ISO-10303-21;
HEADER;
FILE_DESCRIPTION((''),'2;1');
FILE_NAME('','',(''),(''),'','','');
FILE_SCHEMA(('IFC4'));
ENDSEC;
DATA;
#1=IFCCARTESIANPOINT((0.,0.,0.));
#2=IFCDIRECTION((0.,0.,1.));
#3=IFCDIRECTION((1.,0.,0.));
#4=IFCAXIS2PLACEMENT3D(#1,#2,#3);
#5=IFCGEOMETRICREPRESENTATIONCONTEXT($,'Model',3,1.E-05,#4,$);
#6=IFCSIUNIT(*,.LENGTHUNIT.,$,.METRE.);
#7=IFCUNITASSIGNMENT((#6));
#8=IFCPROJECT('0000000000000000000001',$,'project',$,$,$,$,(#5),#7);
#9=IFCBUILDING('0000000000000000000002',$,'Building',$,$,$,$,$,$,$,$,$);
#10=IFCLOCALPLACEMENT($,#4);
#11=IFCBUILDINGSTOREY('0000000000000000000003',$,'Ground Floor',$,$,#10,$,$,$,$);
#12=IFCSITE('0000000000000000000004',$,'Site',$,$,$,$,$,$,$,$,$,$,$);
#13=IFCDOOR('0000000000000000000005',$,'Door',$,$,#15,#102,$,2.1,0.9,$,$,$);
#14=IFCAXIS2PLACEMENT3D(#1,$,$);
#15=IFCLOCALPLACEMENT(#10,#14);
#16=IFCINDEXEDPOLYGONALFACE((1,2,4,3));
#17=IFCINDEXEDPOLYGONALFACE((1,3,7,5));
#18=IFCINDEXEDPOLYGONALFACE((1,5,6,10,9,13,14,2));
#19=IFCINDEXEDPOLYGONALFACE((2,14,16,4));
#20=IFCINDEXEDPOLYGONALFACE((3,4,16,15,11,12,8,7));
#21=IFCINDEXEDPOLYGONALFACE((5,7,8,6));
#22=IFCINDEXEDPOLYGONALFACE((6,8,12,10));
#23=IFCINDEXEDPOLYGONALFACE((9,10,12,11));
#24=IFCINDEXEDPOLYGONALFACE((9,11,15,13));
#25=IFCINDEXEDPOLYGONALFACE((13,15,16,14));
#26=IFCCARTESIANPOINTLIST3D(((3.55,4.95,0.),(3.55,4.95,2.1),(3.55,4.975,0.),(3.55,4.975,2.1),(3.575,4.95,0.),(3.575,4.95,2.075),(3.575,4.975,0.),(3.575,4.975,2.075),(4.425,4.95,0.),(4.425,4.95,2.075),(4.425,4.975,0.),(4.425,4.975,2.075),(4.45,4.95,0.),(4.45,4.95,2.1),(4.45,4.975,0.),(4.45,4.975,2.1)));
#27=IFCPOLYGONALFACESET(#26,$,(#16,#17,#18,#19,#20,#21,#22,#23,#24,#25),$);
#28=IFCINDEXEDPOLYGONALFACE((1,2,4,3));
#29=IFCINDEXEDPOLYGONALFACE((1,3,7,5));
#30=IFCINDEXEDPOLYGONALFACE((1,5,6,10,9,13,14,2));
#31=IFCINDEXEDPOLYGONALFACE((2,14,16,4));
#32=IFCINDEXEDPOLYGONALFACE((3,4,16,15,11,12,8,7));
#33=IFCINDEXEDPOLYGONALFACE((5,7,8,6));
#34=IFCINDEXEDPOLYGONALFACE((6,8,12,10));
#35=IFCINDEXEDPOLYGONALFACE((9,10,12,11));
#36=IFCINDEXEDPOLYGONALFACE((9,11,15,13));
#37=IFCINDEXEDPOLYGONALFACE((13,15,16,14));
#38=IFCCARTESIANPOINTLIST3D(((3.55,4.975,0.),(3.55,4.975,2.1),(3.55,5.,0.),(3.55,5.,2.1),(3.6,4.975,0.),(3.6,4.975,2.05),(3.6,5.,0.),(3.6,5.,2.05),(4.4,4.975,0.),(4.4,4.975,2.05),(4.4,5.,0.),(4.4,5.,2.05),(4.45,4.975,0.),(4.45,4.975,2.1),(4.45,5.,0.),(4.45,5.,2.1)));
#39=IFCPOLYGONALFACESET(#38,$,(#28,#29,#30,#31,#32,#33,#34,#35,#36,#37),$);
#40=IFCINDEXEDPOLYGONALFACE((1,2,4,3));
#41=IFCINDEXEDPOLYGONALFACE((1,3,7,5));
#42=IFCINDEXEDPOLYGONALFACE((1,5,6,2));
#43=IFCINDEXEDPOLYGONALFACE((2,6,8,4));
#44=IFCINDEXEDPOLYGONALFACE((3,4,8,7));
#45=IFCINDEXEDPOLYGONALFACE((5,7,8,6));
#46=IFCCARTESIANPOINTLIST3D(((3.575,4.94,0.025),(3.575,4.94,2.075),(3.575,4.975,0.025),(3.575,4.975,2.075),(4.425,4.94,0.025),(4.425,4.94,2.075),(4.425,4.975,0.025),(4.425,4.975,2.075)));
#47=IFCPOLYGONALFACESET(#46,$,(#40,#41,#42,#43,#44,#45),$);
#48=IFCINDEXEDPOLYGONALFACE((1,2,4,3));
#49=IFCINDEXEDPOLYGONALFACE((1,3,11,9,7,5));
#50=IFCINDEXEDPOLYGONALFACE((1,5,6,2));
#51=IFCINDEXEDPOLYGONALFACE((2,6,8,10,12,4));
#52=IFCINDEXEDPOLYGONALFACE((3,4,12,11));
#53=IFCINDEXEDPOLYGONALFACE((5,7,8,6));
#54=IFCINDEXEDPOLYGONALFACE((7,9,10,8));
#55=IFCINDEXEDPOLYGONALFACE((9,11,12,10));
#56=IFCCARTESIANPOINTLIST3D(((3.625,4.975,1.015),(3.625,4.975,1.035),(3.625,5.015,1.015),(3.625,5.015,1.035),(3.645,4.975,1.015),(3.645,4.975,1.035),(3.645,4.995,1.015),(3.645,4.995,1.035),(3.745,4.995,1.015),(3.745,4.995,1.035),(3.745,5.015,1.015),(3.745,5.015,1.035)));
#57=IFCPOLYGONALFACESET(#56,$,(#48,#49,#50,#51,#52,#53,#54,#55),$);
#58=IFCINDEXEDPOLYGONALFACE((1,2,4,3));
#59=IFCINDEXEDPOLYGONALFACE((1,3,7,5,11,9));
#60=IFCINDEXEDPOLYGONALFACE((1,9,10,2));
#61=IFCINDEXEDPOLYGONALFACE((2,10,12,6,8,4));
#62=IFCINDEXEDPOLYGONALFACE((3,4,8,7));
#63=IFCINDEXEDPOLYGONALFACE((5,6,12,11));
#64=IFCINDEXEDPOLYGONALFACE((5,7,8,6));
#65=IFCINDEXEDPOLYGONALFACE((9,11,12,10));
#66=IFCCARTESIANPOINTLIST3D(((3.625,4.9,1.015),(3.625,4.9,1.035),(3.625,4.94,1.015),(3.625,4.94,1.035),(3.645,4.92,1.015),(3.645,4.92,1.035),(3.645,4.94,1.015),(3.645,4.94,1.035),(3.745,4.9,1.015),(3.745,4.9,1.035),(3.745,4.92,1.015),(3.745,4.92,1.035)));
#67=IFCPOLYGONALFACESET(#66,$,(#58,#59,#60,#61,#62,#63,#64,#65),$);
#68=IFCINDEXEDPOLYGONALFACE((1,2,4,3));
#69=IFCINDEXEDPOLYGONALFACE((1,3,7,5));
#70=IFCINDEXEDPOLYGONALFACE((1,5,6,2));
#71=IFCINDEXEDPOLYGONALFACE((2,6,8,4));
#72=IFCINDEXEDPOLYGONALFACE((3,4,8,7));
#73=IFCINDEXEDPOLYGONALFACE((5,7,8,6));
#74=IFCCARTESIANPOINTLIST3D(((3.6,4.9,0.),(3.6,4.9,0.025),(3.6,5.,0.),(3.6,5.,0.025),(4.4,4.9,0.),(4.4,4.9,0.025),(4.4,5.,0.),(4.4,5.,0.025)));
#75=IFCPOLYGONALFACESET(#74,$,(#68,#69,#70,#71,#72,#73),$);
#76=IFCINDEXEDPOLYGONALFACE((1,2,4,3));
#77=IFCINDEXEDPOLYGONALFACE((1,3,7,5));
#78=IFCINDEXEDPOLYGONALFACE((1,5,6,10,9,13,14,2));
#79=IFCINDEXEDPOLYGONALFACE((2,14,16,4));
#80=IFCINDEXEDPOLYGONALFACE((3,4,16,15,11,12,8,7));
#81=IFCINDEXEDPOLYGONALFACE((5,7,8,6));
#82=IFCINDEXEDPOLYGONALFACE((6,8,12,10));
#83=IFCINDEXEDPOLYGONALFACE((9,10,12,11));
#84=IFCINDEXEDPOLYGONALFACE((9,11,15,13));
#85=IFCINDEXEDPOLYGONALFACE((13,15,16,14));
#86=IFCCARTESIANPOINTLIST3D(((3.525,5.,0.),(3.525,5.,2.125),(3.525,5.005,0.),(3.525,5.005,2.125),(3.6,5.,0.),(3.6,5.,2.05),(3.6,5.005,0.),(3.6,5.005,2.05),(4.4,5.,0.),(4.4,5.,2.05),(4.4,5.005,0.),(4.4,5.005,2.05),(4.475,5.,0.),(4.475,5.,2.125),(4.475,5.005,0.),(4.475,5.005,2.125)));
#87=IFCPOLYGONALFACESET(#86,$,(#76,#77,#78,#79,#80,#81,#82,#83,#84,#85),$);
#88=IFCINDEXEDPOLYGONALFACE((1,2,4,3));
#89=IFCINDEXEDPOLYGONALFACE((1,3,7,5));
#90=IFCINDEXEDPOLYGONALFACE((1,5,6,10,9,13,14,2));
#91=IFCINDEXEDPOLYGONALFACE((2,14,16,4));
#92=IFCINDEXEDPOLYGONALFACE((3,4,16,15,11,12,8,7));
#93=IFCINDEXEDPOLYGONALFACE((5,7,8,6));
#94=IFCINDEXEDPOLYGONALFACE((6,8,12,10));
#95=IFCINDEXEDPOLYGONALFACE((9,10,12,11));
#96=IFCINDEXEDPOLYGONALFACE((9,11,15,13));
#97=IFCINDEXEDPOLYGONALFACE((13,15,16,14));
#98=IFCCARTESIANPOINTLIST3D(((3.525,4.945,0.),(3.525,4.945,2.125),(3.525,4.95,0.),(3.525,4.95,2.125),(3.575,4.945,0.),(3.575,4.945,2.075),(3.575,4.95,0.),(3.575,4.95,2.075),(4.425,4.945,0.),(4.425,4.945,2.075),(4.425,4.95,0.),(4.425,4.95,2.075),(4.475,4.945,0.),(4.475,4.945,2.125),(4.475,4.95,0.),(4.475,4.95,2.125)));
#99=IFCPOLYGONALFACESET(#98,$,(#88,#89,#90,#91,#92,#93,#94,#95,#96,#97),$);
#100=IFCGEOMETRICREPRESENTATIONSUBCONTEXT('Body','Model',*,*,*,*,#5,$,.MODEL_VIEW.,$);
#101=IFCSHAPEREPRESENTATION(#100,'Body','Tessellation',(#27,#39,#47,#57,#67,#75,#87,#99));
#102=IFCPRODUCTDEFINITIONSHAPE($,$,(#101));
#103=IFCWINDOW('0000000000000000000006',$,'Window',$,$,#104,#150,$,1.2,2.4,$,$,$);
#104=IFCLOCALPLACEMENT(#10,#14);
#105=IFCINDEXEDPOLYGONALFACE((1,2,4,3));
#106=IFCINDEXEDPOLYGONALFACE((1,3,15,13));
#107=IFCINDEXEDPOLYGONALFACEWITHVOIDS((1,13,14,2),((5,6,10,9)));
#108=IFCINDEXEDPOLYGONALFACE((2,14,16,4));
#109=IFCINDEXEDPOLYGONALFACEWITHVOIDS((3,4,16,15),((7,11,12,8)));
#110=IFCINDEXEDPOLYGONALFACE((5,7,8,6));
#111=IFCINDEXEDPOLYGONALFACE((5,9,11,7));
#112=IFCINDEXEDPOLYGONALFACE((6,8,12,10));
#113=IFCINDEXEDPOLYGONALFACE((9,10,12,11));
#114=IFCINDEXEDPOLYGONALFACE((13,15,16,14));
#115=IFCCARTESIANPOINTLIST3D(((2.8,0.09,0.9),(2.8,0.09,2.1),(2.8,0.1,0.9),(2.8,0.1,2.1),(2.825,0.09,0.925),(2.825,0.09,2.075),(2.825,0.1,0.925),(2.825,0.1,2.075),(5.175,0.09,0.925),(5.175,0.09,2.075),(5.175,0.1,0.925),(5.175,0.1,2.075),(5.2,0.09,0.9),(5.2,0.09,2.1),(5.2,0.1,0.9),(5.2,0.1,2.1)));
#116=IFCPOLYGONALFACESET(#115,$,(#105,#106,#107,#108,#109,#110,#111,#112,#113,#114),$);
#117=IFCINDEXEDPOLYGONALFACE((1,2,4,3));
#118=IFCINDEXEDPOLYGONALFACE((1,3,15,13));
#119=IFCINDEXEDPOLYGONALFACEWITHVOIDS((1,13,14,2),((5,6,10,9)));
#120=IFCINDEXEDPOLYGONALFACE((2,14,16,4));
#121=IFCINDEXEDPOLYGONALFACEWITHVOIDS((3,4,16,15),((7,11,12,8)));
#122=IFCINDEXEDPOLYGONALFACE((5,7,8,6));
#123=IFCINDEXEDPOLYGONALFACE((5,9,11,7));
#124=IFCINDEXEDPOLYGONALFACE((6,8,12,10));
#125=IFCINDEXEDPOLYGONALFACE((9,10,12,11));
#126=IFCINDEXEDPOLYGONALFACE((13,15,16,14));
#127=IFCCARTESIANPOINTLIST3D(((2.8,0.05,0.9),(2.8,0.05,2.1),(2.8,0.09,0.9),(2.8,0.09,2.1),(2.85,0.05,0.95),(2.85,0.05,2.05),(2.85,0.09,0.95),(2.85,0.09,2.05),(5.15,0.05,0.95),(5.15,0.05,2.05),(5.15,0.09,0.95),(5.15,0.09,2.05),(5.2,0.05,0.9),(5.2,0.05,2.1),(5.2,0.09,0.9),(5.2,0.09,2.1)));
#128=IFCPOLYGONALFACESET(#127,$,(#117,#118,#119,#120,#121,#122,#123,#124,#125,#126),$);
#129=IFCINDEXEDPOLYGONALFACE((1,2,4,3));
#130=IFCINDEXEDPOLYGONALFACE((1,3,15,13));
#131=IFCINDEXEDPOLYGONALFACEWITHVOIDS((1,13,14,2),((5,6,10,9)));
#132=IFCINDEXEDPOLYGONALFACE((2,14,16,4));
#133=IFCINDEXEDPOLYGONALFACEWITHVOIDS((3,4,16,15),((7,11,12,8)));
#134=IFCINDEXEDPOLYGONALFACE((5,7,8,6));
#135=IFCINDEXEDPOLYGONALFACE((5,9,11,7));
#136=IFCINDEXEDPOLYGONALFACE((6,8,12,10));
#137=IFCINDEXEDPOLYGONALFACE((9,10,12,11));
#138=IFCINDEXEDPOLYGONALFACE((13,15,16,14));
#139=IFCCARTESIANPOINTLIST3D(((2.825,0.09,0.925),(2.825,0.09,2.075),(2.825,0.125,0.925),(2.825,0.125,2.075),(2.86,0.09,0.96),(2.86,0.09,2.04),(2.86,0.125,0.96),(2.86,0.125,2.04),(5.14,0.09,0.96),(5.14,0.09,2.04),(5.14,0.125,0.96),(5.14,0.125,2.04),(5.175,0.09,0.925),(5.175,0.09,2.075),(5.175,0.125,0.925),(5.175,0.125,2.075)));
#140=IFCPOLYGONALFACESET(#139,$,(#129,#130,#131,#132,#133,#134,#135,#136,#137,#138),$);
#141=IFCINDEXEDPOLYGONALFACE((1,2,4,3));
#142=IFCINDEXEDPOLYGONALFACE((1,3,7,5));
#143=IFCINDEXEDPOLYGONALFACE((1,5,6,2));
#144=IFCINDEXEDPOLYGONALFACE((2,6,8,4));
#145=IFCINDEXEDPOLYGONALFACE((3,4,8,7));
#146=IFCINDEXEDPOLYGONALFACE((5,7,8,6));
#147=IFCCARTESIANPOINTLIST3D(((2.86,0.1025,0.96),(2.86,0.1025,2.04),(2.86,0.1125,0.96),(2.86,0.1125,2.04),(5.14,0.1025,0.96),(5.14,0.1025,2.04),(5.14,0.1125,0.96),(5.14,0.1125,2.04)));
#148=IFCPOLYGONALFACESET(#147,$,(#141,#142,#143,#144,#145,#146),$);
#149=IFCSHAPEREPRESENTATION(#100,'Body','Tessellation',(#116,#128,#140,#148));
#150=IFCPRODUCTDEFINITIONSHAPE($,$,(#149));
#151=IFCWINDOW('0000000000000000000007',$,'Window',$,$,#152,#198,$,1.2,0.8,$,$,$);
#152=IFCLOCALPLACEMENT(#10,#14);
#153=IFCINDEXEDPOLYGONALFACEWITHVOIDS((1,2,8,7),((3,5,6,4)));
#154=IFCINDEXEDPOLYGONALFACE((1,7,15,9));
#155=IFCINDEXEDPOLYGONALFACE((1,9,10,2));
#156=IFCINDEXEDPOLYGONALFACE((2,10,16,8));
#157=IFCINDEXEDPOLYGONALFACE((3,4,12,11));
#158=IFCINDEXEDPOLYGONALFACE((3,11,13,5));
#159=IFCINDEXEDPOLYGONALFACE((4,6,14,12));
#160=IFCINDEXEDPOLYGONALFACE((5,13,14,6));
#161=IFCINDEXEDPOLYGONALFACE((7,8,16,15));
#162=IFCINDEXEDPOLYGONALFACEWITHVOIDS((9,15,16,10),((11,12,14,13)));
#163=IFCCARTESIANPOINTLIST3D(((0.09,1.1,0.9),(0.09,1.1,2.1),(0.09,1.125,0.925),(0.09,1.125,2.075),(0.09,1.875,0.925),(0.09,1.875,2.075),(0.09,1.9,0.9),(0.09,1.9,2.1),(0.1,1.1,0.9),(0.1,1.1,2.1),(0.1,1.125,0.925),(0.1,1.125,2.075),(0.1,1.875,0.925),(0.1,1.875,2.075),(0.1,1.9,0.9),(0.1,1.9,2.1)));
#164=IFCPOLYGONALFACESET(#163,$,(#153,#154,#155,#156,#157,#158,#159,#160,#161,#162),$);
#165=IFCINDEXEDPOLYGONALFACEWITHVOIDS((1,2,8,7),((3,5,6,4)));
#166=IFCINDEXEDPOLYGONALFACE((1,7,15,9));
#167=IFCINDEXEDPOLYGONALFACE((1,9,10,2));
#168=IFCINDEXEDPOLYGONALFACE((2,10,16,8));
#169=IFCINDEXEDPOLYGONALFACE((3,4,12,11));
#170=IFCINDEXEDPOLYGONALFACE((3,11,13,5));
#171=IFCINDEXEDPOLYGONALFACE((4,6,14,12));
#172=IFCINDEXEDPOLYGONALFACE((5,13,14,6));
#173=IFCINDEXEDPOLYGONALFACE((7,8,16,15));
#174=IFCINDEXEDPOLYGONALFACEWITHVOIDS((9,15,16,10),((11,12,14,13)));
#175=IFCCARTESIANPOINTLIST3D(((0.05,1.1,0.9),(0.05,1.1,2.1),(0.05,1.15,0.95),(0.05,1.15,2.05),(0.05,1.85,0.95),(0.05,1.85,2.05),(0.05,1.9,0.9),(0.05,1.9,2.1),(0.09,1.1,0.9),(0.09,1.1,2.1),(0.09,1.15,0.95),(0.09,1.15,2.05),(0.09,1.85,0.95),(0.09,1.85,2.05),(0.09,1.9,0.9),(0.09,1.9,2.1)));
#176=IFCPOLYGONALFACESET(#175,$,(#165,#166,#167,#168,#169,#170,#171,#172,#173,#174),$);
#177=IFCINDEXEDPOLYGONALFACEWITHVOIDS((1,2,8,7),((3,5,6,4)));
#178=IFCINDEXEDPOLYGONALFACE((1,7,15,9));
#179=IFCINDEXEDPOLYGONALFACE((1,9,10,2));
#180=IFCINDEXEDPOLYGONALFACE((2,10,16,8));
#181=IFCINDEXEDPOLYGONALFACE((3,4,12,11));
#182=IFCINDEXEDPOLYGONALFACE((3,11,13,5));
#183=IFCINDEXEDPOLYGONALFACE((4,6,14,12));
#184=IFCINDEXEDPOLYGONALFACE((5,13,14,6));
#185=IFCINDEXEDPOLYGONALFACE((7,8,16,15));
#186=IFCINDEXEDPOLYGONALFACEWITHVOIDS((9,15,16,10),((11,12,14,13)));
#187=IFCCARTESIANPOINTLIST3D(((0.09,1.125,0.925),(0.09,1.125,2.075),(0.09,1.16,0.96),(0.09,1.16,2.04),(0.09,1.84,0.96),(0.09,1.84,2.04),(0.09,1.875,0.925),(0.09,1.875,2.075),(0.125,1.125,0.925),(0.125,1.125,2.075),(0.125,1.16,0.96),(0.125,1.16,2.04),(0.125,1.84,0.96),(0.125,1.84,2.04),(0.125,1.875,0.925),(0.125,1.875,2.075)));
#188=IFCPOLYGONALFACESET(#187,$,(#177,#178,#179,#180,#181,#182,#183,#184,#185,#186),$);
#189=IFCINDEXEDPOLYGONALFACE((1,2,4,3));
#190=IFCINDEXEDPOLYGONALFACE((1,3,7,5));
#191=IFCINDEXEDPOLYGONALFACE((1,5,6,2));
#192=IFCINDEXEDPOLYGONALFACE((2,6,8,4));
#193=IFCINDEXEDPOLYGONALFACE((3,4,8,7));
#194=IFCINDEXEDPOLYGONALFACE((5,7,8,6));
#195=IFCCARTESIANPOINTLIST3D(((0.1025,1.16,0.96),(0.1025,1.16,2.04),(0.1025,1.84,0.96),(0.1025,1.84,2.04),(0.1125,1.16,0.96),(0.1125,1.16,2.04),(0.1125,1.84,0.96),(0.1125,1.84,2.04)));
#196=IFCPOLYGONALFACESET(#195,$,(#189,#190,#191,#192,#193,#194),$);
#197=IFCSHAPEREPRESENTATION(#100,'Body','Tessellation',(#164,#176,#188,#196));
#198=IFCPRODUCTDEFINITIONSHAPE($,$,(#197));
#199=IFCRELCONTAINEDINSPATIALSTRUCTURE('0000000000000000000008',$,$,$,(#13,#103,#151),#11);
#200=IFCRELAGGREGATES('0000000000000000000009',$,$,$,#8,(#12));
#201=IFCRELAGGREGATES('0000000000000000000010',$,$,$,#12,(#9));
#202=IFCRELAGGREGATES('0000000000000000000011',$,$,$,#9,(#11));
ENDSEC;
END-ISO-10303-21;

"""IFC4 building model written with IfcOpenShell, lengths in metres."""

from ifc_helpers import new_model, si_unit, frame, origin_with_axes, place, context, subcontext, project, spatial, line, indexed_curve, outline, extrude, element, save


model = new_model("IFC4")

# Units and contexts
model_context = context("Model", 3, precision=1e-05, world=origin_with_axes())
body_context = subcontext(model_context, "Body", "Model", "MODEL_VIEW")
ifc_project = project(units=[si_unit("LENGTHUNIT", "METRE")], contexts=[model_context])

# Site, building, storey
site = spatial("IfcSite", under=ifc_project, Name="Site")
building = spatial("IfcBuilding", under=site, Name="Building")
storey_placement = place(None, origin_with_axes())
storey = spatial("IfcBuildingStorey", under=building, at=storey_placement, Name="Ground Floor")

# Door
door_1_placement = place(storey_placement, frame((4.45, 5.0, 0.0), z_axis=(0.0, 0.0, 1.0), x_axis=(-1.0, 0.0, 0.0)))
element("IfcDoor", 1, at=door_1_placement, inside=storey, Name="Door", OverallHeight=2.1, OverallWidth=0.9, context=body_context, shape_type="SweptSolid", body=[
    extrude(outline(indexed_curve([(0.0, 0.0), (0.0, 2.1), (0.9, 2.1), (0.9, 0.0), (0.875, 0.0), (0.875, 2.075), (0.025, 2.075), (0.025, 0.0)], segments=[line(1, 2, 3, 4, 5, 6, 7, 8, 1)])), frame((0.0, 0.025, 0.0), z_axis=(0.0, -1.0, 0.0), x_axis=(1.0, 0.0, 0.0)), (0.0, 0.0, -1.0), 0.025),
    extrude(outline(indexed_curve([(0.0, 0.0), (0.0, 2.1), (0.9, 2.1), (0.9, 0.0), (0.85, 0.0), (0.85, 2.05), (0.05, 2.05), (0.05, 0.0)], segments=[line(1, 2, 3, 4, 5, 6, 7, 8, 1)])), frame((0.0, 0.0, 0.0), z_axis=(0.0, -1.0, 0.0), x_axis=(1.0, 0.0, 0.0)), (0.0, 0.0, -1.0), 0.025),
    extrude(outline(indexed_curve([(0.0, 0.0), (0.85, 0.0), (0.85, 0.035), (0.0, 0.035)], segments=[line(1, 2, 3, 4, 1)])), frame((0.025, 0.025, 0.025), z_axis=(0.0, 0.0, 1.0), x_axis=(1.0, 0.0, 0.0)), (0.0, 0.0, 1.0), 2.05),
    extrude(outline(indexed_curve([(0.0, 0.0), (0.0, -0.04), (-0.12, -0.04), (-0.12, -0.02), (-0.02, -0.02), (-0.02, 0.0)], segments=[line(1, 2, 3, 4, 5, 6, 1)])), frame((0.825, 0.025, 1.015), z_axis=(0.0, 0.0, 1.0), x_axis=(1.0, 0.0, 0.0)), (0.0, 0.0, 1.0), 0.02),
    extrude(outline(indexed_curve([(0.0, 0.0), (0.0, 0.04), (-0.12, 0.04), (-0.12, 0.02), (-0.02, 0.02), (-0.02, 0.0)], segments=[line(1, 2, 3, 4, 5, 6, 1)])), frame((0.825, 0.06, 1.015), z_axis=(0.0, 0.0, 1.0), x_axis=(1.0, 0.0, 0.0)), (0.0, 0.0, 1.0), 0.02),
    extrude(outline(indexed_curve([(0.0, 0.0), (0.8, 0.0), (0.8, 0.1), (0.0, 0.1)], segments=[line(1, 2, 3, 4, 1)])), frame((0.05, 0.0, 0.0), z_axis=(0.0, 0.0, 1.0), x_axis=(1.0, 0.0, 0.0)), (0.0, 0.0, 1.0), 0.025),
    extrude(outline(indexed_curve([(0.0, 0.0), (0.0, 2.125), (0.95, 2.125), (0.95, 0.0), (0.875, 0.0), (0.875, 2.05), (0.075, 2.05), (0.075, 0.0)], segments=[line(1, 2, 3, 4, 5, 6, 7, 8, 1)])), frame((-0.025, -0.005, 0.0), z_axis=(0.0, -1.0, 0.0), x_axis=(1.0, 0.0, 0.0)), (0.0, 0.0, -1.0), 0.005),
    extrude(outline(indexed_curve([(0.0, 0.0), (0.0, 2.125), (0.95, 2.125), (0.95, 0.0), (0.9, 0.0), (0.9, 2.075), (0.05, 2.075), (0.05, 0.0)], segments=[line(1, 2, 3, 4, 5, 6, 7, 8, 1)])), frame((-0.025, 0.05, 0.0), z_axis=(0.0, -1.0, 0.0), x_axis=(1.0, 0.0, 0.0)), (0.0, 0.0, -1.0), 0.005),
])

# Windows
window_1_placement = place(storey_placement, frame((2.8, 0.0, 0.9), z_axis=(0.0, 0.0, 1.0), x_axis=(1.0, 0.0, 0.0)))
element("IfcWindow", 2, at=window_1_placement, inside=storey, Name="Window", OverallHeight=1.2, OverallWidth=2.4, context=body_context, shape_type="SweptSolid", body=[
    extrude(outline(indexed_curve([(0.0, 0.0), (2.4, 0.0), (2.4, 1.2), (0.0, 1.2)], segments=[line(1, 2, 3, 4, 1)]), holes=[indexed_curve([(0.025, 0.025), (2.375, 0.025), (2.375, 1.175), (0.025, 1.175)], segments=[line(1, 2, 3, 4, 1)])]), frame((0.0, 0.09, 0.0), z_axis=(0.0, -1.0, 0.0), x_axis=(1.0, 0.0, 0.0)), (0.0, 0.0, -1.0), 0.01),
    extrude(outline(indexed_curve([(0.0, 0.0), (2.4, 0.0), (2.4, 1.2), (0.0, 1.2)], segments=[line(1, 2, 3, 4, 1)]), holes=[indexed_curve([(0.05, 0.05), (2.35, 0.05), (2.35, 1.15), (0.05, 1.15)], segments=[line(1, 2, 3, 4, 1)])]), frame((0.0, 0.05, 0.0), z_axis=(0.0, -1.0, 0.0), x_axis=(1.0, 0.0, 0.0)), (0.0, 0.0, -1.0), 0.04),
    extrude(outline(indexed_curve([(0.0, 0.0), (2.35, 0.0), (2.35, 1.15), (0.0, 1.15)], segments=[line(1, 2, 3, 4, 1)]), holes=[indexed_curve([(0.035, 0.035), (2.315, 0.035), (2.315, 1.115), (0.035, 1.115)], segments=[line(1, 2, 3, 4, 1)])]), frame((0.025, 0.09, 0.025), z_axis=(0.0, -1.0, 0.0), x_axis=(1.0, 0.0, 0.0)), (0.0, 0.0, -1.0), 0.035),
    extrude(outline(indexed_curve([(0.035, 0.035), (2.315, 0.035), (2.315, 1.115), (0.035, 1.115)], segments=[line(1, 2, 3, 4, 1)])), frame((0.025, 0.1025, 0.025), z_axis=(0.0, -1.0, 0.0), x_axis=(1.0, 0.0, 0.0)), (0.0, 0.0, -1.0), 0.01),
])
window_2_placement = place(storey_placement, frame((0.0, 1.9, 0.9), z_axis=(0.0, 0.0, 1.0), x_axis=(0.0, -1.0, 0.0)))
element("IfcWindow", 3, at=window_2_placement, inside=storey, Name="Window", OverallHeight=1.2, OverallWidth=0.8, context=body_context, shape_type="SweptSolid", body=[
    extrude(outline(indexed_curve([(0.0, 0.0), (0.8, 0.0), (0.8, 1.2), (0.0, 1.2)], segments=[line(1, 2, 3, 4, 1)]), holes=[indexed_curve([(0.025, 0.025), (0.775, 0.025), (0.775, 1.175), (0.025, 1.175)], segments=[line(1, 2, 3, 4, 1)])]), frame((0.0, 0.09, 0.0), z_axis=(0.0, -1.0, 0.0), x_axis=(1.0, 0.0, 0.0)), (0.0, 0.0, -1.0), 0.01),
    extrude(outline(indexed_curve([(0.0, 0.0), (0.8, 0.0), (0.8, 1.2), (0.0, 1.2)], segments=[line(1, 2, 3, 4, 1)]), holes=[indexed_curve([(0.05, 0.05), (0.75, 0.05), (0.75, 1.15), (0.05, 1.15)], segments=[line(1, 2, 3, 4, 1)])]), frame((0.0, 0.05, 0.0), z_axis=(0.0, -1.0, 0.0), x_axis=(1.0, 0.0, 0.0)), (0.0, 0.0, -1.0), 0.04),
    extrude(outline(indexed_curve([(0.0, 0.0), (0.75, 0.0), (0.75, 1.15), (0.0, 1.15)], segments=[line(1, 2, 3, 4, 1)]), holes=[indexed_curve([(0.035, 0.035), (0.715, 0.035), (0.715, 1.115), (0.035, 1.115)], segments=[line(1, 2, 3, 4, 1)])]), frame((0.025, 0.09, 0.025), z_axis=(0.0, -1.0, 0.0), x_axis=(1.0, 0.0, 0.0)), (0.0, 0.0, -1.0), 0.035),
    extrude(outline(indexed_curve([(0.035, 0.035), (0.715, 0.035), (0.715, 1.115), (0.035, 1.115)], segments=[line(1, 2, 3, 4, 1)])), frame((0.025, 0.1025, 0.025), z_axis=(0.0, -1.0, 0.0), x_axis=(1.0, 0.0, 0.0)), (0.0, 0.0, -1.0), 0.01),
])

save(model, "model.ifc")
